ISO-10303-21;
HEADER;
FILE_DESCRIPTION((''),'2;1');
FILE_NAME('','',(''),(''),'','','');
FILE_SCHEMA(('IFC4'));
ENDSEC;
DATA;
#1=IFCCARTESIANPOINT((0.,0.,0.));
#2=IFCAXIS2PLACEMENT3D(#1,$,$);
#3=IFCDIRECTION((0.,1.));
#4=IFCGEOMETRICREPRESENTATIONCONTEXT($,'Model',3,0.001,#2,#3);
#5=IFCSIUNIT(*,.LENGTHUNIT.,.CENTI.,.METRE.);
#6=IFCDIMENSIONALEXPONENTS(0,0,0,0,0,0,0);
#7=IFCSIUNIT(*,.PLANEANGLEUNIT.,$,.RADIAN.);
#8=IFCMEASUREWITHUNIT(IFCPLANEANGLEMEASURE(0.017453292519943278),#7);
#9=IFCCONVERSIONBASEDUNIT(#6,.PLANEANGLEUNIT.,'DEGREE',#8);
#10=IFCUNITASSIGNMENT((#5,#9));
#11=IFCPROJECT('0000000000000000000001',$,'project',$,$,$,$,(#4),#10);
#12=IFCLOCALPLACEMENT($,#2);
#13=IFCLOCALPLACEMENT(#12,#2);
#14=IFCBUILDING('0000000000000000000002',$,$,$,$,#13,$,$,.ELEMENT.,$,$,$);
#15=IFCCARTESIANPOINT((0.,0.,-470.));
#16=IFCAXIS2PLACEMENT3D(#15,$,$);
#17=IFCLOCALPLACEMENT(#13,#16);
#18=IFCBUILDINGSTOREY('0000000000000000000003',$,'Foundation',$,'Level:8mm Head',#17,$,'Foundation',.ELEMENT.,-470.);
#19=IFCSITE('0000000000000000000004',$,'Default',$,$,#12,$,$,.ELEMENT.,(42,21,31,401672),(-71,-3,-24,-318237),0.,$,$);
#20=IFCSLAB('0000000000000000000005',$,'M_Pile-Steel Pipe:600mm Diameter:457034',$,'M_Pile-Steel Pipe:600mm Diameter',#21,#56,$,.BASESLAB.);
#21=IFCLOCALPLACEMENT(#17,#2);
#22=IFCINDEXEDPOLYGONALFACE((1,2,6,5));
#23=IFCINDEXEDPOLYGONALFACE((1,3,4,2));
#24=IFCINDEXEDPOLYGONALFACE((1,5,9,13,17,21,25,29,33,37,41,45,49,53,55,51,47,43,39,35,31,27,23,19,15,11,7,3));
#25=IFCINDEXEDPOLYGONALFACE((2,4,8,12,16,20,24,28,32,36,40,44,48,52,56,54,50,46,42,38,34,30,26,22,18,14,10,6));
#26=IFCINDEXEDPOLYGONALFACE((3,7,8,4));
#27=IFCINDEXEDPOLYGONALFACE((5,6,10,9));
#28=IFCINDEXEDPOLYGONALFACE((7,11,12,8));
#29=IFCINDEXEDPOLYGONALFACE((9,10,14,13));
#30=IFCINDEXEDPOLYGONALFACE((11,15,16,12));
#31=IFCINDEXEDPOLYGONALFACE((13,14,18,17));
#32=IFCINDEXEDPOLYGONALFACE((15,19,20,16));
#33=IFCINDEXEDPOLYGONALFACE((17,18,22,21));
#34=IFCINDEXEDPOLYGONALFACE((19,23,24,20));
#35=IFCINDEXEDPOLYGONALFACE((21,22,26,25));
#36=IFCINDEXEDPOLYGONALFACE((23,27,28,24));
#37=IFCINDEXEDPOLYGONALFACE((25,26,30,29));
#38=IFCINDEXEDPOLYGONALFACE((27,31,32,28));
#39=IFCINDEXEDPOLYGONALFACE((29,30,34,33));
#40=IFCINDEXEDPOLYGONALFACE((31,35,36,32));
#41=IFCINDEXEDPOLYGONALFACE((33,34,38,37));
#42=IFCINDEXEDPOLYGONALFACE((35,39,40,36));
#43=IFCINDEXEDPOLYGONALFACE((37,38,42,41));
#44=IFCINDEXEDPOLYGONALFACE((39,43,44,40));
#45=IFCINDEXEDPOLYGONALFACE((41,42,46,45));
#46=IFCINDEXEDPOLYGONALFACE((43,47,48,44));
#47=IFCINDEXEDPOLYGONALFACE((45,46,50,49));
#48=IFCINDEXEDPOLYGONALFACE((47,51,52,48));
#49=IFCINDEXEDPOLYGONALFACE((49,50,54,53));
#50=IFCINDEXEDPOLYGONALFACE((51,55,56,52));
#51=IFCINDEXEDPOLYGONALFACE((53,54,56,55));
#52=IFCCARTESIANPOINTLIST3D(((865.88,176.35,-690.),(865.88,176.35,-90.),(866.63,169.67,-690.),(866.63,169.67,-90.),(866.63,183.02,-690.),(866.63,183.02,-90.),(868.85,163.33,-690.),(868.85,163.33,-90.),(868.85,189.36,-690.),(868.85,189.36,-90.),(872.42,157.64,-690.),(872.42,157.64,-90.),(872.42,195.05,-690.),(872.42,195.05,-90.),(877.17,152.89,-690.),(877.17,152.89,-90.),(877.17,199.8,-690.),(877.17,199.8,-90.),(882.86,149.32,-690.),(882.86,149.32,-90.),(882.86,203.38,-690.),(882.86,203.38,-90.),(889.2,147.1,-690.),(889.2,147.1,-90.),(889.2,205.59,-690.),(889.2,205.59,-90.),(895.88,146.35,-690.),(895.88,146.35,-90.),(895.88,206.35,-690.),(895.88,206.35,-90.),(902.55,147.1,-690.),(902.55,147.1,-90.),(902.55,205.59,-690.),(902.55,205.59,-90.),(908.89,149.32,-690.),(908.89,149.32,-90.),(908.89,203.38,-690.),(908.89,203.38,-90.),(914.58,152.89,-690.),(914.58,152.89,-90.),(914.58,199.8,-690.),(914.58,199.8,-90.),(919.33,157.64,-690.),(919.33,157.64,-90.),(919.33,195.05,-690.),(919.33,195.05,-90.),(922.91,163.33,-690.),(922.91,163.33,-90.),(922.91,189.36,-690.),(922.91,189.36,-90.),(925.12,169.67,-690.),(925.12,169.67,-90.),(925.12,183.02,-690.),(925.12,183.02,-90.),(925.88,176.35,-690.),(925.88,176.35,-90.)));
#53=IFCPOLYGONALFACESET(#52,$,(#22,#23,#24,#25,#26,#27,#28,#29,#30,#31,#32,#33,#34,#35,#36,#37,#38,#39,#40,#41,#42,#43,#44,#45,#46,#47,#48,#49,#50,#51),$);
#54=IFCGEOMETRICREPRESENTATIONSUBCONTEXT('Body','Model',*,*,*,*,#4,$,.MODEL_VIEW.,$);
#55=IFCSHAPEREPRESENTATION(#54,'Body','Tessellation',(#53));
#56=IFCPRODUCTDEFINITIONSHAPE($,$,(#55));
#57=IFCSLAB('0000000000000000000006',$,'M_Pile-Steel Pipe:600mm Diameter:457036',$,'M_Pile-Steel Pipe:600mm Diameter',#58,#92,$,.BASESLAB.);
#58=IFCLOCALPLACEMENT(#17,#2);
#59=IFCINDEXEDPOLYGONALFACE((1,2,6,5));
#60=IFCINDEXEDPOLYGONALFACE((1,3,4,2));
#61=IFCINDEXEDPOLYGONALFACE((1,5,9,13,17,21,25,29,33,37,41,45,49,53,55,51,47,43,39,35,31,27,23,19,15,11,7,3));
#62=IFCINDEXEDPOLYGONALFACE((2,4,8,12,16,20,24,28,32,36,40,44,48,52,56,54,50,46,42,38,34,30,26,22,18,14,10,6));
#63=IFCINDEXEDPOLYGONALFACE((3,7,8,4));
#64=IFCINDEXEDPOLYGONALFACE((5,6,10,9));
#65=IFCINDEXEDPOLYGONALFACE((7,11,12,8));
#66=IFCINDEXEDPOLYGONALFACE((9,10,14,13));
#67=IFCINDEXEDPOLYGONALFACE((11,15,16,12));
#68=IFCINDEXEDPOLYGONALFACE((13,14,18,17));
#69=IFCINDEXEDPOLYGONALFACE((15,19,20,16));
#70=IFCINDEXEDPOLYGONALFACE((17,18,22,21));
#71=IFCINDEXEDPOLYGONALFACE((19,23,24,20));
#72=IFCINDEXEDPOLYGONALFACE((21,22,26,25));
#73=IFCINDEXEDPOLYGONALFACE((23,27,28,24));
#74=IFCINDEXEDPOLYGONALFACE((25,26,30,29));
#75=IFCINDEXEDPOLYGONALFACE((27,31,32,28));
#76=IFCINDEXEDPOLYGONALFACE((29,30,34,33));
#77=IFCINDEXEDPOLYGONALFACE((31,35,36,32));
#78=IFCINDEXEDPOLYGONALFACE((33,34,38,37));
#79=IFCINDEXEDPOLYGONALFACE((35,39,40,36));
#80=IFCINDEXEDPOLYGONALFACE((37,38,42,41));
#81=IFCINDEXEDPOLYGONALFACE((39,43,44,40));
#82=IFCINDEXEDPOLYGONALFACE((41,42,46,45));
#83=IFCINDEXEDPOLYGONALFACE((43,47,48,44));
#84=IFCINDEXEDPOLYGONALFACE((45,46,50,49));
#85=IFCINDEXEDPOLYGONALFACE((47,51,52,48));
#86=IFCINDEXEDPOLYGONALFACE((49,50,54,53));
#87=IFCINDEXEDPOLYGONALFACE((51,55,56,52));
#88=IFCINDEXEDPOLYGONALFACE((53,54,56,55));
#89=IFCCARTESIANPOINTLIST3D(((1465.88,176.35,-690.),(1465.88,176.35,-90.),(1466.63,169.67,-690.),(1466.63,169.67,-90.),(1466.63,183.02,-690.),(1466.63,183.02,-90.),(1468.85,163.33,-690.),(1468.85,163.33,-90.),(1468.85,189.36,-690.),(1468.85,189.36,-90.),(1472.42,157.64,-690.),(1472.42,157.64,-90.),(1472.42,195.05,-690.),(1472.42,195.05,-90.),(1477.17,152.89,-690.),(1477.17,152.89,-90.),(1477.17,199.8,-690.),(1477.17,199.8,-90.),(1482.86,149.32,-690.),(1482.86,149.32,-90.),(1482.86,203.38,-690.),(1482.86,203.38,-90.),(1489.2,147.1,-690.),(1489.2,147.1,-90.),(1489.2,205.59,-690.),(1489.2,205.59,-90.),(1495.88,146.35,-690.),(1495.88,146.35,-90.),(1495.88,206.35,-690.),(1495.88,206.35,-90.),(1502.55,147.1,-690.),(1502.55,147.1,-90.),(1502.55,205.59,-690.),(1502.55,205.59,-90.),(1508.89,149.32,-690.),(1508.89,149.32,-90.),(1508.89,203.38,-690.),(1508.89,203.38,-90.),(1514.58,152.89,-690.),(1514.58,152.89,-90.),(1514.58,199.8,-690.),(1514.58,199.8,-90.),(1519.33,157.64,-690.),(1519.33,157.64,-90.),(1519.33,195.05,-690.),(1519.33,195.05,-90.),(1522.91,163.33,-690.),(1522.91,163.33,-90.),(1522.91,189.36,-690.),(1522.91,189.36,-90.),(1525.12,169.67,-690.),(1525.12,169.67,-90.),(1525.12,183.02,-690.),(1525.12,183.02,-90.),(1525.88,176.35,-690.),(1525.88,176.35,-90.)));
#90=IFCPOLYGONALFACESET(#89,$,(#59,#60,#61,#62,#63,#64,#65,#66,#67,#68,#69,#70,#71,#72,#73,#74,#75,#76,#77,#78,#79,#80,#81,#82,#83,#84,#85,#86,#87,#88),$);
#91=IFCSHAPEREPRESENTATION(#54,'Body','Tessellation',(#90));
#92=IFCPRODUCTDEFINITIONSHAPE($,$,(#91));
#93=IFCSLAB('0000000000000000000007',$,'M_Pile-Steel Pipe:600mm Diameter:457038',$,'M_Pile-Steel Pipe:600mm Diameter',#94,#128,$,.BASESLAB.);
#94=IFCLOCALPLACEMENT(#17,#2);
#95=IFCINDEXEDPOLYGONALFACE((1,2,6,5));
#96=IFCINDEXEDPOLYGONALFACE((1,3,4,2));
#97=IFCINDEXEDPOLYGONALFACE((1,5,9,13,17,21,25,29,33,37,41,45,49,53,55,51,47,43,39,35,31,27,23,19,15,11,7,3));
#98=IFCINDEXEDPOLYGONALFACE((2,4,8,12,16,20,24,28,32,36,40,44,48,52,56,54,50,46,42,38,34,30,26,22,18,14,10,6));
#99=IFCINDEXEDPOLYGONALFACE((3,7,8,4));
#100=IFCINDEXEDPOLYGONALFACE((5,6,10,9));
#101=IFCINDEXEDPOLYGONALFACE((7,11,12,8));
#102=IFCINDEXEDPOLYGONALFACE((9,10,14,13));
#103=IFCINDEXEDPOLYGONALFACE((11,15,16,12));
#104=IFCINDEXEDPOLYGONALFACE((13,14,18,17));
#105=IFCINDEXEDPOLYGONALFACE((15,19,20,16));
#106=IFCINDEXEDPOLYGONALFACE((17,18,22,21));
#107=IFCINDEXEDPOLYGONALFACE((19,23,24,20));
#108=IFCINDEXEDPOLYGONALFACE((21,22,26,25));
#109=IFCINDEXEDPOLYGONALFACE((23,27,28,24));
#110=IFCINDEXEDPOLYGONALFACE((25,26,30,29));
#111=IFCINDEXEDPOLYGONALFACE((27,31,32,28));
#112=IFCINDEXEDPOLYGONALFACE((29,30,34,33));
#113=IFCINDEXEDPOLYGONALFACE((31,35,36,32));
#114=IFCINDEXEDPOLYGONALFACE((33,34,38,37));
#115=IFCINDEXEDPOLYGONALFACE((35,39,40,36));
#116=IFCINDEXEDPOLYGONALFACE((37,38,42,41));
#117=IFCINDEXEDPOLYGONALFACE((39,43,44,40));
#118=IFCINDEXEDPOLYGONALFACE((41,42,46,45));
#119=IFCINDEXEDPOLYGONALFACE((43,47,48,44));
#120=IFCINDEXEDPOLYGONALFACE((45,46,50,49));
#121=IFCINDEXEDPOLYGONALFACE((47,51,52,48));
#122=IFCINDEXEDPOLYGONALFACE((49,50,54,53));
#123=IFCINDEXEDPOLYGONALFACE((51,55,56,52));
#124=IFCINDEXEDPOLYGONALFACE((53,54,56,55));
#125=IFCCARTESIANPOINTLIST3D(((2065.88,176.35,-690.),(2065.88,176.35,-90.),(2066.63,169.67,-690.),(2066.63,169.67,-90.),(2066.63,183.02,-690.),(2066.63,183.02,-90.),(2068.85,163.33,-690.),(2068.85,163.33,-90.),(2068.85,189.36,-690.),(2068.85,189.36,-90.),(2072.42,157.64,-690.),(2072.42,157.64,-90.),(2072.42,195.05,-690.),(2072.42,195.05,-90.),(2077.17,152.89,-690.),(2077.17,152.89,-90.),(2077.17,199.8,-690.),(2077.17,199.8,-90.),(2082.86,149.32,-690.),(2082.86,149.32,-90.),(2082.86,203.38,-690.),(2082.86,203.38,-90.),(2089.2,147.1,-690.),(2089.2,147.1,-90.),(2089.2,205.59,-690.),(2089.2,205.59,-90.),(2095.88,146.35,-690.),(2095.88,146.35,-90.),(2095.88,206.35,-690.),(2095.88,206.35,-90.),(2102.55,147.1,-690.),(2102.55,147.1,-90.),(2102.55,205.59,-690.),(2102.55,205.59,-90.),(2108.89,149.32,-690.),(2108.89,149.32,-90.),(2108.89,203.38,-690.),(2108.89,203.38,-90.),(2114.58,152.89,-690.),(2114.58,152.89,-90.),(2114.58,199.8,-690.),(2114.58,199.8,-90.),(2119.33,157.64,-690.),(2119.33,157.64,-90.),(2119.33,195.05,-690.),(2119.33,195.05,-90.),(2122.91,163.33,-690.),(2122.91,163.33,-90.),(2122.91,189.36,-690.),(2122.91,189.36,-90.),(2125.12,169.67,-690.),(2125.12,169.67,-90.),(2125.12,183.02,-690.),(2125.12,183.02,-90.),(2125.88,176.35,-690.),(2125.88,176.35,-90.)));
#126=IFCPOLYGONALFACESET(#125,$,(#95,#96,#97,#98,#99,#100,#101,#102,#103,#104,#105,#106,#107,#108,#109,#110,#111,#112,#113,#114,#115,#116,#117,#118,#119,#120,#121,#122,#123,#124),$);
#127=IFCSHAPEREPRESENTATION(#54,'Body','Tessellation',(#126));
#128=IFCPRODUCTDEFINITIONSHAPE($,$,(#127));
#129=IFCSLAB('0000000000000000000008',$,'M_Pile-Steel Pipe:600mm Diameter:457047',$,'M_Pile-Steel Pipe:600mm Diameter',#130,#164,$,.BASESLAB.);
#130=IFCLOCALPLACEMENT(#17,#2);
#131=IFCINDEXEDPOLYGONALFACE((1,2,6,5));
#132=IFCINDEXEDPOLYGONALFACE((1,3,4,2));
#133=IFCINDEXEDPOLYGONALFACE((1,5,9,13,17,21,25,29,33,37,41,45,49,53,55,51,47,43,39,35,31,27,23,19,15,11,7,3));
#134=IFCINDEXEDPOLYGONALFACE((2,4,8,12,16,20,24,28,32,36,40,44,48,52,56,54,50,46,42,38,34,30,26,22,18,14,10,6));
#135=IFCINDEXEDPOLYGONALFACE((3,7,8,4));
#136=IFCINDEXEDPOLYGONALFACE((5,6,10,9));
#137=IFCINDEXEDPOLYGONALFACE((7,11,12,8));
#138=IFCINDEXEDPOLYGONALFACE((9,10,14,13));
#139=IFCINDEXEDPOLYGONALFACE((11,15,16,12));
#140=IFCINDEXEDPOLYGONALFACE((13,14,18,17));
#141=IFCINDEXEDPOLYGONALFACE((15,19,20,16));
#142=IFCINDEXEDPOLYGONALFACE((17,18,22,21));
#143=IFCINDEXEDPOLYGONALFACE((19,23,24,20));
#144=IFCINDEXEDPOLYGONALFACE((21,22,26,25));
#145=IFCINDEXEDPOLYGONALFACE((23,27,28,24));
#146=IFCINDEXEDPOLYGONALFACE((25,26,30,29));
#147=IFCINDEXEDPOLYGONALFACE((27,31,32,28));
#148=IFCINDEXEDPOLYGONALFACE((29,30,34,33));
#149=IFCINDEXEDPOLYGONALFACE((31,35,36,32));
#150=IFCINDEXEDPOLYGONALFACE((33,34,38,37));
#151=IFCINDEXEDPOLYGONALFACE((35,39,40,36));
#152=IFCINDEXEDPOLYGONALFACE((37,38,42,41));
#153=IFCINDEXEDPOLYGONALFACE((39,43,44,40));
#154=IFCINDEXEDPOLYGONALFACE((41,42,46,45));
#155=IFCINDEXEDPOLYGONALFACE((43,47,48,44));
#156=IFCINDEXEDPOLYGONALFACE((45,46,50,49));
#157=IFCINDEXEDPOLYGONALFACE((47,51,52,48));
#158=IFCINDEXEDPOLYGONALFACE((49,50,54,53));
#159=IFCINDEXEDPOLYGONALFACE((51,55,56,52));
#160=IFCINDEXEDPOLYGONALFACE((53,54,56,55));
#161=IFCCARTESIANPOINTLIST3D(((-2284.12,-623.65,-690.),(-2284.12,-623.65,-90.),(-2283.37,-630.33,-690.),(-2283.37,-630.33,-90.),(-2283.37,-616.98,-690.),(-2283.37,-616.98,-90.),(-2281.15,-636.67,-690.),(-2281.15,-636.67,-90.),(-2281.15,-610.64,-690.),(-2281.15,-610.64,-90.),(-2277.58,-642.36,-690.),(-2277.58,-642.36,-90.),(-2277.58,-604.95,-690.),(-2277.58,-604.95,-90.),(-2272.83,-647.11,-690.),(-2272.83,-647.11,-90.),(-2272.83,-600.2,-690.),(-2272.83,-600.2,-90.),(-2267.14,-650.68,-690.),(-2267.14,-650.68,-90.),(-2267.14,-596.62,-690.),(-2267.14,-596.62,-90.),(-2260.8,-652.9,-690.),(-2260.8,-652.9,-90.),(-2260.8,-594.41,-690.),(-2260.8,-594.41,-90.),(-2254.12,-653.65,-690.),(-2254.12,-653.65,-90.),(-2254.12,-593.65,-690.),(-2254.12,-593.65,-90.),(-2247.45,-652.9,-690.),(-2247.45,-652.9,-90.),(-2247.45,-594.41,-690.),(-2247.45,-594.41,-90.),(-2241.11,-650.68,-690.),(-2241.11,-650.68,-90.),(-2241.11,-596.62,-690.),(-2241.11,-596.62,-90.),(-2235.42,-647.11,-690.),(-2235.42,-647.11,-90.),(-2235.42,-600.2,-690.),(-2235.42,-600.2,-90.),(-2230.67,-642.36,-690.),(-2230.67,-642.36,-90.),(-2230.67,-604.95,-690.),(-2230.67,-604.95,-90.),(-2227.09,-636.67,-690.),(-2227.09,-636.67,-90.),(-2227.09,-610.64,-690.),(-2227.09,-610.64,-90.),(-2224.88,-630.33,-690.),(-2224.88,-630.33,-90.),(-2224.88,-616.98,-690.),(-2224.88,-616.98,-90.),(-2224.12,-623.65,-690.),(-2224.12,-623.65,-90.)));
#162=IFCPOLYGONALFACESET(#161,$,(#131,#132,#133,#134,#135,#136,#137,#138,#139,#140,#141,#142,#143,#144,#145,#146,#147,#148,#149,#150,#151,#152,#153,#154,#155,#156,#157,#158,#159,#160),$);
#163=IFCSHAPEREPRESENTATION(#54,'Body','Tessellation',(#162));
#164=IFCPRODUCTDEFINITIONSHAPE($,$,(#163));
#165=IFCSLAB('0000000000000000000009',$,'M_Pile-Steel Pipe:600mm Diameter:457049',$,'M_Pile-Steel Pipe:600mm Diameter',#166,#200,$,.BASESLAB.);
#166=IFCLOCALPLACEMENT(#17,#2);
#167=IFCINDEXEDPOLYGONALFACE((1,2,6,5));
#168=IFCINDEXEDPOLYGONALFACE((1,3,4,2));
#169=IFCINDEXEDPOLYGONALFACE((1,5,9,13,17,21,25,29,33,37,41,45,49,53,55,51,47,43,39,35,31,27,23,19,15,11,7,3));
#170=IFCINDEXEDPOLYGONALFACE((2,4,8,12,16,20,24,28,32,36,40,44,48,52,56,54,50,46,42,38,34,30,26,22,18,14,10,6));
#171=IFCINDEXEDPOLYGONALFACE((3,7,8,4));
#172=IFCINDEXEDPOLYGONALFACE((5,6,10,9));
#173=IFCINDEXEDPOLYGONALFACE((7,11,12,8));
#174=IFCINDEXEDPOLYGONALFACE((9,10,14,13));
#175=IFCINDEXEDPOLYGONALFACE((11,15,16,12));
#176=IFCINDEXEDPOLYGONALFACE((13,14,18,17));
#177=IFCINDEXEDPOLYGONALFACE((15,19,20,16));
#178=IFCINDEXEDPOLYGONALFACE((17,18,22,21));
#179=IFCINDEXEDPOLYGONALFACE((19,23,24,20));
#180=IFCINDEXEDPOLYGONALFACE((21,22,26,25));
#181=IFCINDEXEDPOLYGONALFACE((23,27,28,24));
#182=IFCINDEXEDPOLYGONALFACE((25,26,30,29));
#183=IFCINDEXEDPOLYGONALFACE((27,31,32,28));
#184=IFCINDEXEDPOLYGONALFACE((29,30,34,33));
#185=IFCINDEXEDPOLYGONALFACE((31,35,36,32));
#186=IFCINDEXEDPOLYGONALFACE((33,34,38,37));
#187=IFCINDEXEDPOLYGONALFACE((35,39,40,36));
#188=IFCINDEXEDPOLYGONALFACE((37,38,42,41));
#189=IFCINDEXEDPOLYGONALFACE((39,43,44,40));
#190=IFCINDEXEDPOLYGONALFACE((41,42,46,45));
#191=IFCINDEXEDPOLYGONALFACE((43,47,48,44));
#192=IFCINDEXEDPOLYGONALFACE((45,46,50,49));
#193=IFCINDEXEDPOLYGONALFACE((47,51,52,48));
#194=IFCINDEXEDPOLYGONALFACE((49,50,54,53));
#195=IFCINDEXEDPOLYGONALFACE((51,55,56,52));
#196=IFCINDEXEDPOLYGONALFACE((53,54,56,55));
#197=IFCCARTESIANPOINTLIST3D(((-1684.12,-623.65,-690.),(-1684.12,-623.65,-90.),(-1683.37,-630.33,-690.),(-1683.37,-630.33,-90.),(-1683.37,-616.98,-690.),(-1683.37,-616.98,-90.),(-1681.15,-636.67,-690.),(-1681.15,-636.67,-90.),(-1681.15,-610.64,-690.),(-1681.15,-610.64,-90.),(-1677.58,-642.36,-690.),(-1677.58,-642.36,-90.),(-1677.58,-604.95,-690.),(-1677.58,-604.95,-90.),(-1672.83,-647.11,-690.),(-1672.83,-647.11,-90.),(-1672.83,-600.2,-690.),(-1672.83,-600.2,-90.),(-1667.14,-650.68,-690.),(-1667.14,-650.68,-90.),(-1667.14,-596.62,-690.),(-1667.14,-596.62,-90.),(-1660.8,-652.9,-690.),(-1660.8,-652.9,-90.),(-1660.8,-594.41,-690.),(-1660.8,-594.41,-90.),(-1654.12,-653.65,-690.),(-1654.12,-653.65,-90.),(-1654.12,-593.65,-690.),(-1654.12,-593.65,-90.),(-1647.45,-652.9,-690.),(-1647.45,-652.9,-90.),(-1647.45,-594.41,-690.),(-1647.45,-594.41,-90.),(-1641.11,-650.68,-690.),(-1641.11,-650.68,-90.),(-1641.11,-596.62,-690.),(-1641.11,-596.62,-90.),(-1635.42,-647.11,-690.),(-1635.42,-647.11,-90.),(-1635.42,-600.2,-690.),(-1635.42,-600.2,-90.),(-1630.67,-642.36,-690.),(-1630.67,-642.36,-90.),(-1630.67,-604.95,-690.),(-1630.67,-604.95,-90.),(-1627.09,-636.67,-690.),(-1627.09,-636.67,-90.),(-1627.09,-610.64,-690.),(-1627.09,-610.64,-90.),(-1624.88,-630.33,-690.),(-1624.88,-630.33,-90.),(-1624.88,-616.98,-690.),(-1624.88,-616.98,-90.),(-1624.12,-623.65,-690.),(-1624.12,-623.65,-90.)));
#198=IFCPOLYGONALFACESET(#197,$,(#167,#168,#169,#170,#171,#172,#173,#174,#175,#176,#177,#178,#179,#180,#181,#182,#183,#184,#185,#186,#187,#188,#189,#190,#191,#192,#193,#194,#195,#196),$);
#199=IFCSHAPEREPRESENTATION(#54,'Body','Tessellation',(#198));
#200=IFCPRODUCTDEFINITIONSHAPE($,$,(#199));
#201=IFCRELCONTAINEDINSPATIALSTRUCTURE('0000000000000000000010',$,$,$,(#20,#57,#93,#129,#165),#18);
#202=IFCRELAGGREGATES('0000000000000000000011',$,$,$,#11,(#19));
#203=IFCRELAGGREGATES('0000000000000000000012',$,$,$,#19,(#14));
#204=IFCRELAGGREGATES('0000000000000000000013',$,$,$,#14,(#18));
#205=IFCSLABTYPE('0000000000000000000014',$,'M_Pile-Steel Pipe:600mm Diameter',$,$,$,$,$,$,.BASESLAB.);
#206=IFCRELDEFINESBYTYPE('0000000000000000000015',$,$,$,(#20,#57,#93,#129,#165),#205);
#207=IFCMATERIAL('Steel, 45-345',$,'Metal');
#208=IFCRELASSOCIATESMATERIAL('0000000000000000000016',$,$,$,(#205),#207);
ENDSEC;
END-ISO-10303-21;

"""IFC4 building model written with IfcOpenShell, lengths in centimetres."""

from ifc_helpers import new_model, entity, si_unit, converted_unit, direction, frame, origin, place, context, subcontext, project, spatial, arc, indexed_curve, outline, extrude, material, type_object, element, save


model = new_model("IFC4")

# Units and contexts
model_context = context("Model", 3, precision=0.001, world=origin(), true_north=direction((0.0, 1.0)))
body_context = subcontext(model_context, "Body", "Model", "MODEL_VIEW")
ifc_project = project(units=[si_unit("LENGTHUNIT", "METRE", prefix="CENTI"), converted_unit("PLANEANGLEUNIT", "DEGREE", entity("IfcPlaneAngleMeasure", 0.017453292519943278), si_unit("PLANEANGLEUNIT", "RADIAN"), dimensions=[0, 0, 0, 0, 0, 0, 0])], contexts=[model_context])

# Site, building, storey
site_placement = place(None, origin())
site = spatial("IfcSite", under=ifc_project, at=site_placement, Name="Default", CompositionType="ELEMENT", RefLatitude=(42, 21, 31, 401672), RefLongitude=(-71, -3, -24, -318237), RefElevation=0.0)
building_placement = place(site_placement, origin())
building = spatial("IfcBuilding", under=site, at=building_placement, CompositionType="ELEMENT")
storey_placement = place(building_placement, frame((0.0, 0.0, -470.0)))
storey = spatial("IfcBuildingStorey", under=building, at=storey_placement, Name="Foundation", ObjectType="Level:8mm Head", LongName="Foundation", CompositionType="ELEMENT", Elevation=-470.0)

# Slabs
ifc_material_1 = material(Name="Steel, 45-345", Category="Metal")
slab_type_1 = type_object("IfcSlabType", Name="M_Pile-Steel Pipe:600mm Diameter", PredefinedType="BASESLAB", material=ifc_material_1)
slab_1_placement = place(storey_placement, origin())
element("IfcSlab", 1, at=slab_1_placement, inside=storey, type_object=slab_type_1, Name="M_Pile-Steel Pipe:600mm Diameter:457034", ObjectType="M_Pile-Steel Pipe:600mm Diameter", PredefinedType="BASESLAB", context=body_context, shape_type="SweptSolid", body=[
    extrude(outline(indexed_curve([(-30.0, 0.0), (0.0, -30.0), (30.0, 0.0), (0.0, 30.0)], segments=[arc(1, 2, 3), arc(3, 4, 1)], self_intersect=False)), frame((895.88, 176.35, -690.0)), (0.0, 0.0, 1.0), 600.0),
])
slab_2_placement = place(storey_placement, origin())
element("IfcSlab", 2, at=slab_2_placement, inside=storey, type_object=slab_type_1, Name="M_Pile-Steel Pipe:600mm Diameter:457036", ObjectType="M_Pile-Steel Pipe:600mm Diameter", PredefinedType="BASESLAB", context=body_context, shape_type="SweptSolid", body=[
    extrude(outline(indexed_curve([(-30.0, 0.0), (0.0, -30.0), (30.0, 0.0), (0.0, 30.0)], segments=[arc(1, 2, 3), arc(3, 4, 1)], self_intersect=False)), frame((1495.88, 176.35, -690.0)), (0.0, 0.0, 1.0), 600.0),
])
slab_3_placement = place(storey_placement, origin())
element("IfcSlab", 3, at=slab_3_placement, inside=storey, type_object=slab_type_1, Name="M_Pile-Steel Pipe:600mm Diameter:457038", ObjectType="M_Pile-Steel Pipe:600mm Diameter", PredefinedType="BASESLAB", context=body_context, shape_type="SweptSolid", body=[
    extrude(outline(indexed_curve([(-30.0, 0.0), (0.0, -30.0), (30.0, 0.0), (0.0, 30.0)], segments=[arc(1, 2, 3), arc(3, 4, 1)], self_intersect=False)), frame((2095.88, 176.35, -690.0)), (0.0, 0.0, 1.0), 600.0),
])
slab_4_placement = place(storey_placement, origin())
element("IfcSlab", 4, at=slab_4_placement, inside=storey, type_object=slab_type_1, Name="M_Pile-Steel Pipe:600mm Diameter:457047", ObjectType="M_Pile-Steel Pipe:600mm Diameter", PredefinedType="BASESLAB", context=body_context, shape_type="SweptSolid", body=[
    extrude(outline(indexed_curve([(-30.0, 0.0), (0.0, -30.0), (30.0, 0.0), (0.0, 30.0)], segments=[arc(1, 2, 3), arc(3, 4, 1)], self_intersect=False)), frame((-2254.12, -623.65, -690.0)), (0.0, 0.0, 1.0), 600.0),
])
slab_5_placement = place(storey_placement, origin())
element("IfcSlab", 5, at=slab_5_placement, inside=storey, type_object=slab_type_1, Name="M_Pile-Steel Pipe:600mm Diameter:457049", ObjectType="M_Pile-Steel Pipe:600mm Diameter", PredefinedType="BASESLAB", context=body_context, shape_type="SweptSolid", body=[
    extrude(outline(indexed_curve([(-30.0, 0.0), (0.0, -30.0), (30.0, 0.0), (0.0, 30.0)], segments=[arc(1, 2, 3), arc(3, 4, 1)], self_intersect=False)), frame((-1654.12, -623.65, -690.0)), (0.0, 0.0, 1.0), 600.0),
])

save(model, "model.ifc")
